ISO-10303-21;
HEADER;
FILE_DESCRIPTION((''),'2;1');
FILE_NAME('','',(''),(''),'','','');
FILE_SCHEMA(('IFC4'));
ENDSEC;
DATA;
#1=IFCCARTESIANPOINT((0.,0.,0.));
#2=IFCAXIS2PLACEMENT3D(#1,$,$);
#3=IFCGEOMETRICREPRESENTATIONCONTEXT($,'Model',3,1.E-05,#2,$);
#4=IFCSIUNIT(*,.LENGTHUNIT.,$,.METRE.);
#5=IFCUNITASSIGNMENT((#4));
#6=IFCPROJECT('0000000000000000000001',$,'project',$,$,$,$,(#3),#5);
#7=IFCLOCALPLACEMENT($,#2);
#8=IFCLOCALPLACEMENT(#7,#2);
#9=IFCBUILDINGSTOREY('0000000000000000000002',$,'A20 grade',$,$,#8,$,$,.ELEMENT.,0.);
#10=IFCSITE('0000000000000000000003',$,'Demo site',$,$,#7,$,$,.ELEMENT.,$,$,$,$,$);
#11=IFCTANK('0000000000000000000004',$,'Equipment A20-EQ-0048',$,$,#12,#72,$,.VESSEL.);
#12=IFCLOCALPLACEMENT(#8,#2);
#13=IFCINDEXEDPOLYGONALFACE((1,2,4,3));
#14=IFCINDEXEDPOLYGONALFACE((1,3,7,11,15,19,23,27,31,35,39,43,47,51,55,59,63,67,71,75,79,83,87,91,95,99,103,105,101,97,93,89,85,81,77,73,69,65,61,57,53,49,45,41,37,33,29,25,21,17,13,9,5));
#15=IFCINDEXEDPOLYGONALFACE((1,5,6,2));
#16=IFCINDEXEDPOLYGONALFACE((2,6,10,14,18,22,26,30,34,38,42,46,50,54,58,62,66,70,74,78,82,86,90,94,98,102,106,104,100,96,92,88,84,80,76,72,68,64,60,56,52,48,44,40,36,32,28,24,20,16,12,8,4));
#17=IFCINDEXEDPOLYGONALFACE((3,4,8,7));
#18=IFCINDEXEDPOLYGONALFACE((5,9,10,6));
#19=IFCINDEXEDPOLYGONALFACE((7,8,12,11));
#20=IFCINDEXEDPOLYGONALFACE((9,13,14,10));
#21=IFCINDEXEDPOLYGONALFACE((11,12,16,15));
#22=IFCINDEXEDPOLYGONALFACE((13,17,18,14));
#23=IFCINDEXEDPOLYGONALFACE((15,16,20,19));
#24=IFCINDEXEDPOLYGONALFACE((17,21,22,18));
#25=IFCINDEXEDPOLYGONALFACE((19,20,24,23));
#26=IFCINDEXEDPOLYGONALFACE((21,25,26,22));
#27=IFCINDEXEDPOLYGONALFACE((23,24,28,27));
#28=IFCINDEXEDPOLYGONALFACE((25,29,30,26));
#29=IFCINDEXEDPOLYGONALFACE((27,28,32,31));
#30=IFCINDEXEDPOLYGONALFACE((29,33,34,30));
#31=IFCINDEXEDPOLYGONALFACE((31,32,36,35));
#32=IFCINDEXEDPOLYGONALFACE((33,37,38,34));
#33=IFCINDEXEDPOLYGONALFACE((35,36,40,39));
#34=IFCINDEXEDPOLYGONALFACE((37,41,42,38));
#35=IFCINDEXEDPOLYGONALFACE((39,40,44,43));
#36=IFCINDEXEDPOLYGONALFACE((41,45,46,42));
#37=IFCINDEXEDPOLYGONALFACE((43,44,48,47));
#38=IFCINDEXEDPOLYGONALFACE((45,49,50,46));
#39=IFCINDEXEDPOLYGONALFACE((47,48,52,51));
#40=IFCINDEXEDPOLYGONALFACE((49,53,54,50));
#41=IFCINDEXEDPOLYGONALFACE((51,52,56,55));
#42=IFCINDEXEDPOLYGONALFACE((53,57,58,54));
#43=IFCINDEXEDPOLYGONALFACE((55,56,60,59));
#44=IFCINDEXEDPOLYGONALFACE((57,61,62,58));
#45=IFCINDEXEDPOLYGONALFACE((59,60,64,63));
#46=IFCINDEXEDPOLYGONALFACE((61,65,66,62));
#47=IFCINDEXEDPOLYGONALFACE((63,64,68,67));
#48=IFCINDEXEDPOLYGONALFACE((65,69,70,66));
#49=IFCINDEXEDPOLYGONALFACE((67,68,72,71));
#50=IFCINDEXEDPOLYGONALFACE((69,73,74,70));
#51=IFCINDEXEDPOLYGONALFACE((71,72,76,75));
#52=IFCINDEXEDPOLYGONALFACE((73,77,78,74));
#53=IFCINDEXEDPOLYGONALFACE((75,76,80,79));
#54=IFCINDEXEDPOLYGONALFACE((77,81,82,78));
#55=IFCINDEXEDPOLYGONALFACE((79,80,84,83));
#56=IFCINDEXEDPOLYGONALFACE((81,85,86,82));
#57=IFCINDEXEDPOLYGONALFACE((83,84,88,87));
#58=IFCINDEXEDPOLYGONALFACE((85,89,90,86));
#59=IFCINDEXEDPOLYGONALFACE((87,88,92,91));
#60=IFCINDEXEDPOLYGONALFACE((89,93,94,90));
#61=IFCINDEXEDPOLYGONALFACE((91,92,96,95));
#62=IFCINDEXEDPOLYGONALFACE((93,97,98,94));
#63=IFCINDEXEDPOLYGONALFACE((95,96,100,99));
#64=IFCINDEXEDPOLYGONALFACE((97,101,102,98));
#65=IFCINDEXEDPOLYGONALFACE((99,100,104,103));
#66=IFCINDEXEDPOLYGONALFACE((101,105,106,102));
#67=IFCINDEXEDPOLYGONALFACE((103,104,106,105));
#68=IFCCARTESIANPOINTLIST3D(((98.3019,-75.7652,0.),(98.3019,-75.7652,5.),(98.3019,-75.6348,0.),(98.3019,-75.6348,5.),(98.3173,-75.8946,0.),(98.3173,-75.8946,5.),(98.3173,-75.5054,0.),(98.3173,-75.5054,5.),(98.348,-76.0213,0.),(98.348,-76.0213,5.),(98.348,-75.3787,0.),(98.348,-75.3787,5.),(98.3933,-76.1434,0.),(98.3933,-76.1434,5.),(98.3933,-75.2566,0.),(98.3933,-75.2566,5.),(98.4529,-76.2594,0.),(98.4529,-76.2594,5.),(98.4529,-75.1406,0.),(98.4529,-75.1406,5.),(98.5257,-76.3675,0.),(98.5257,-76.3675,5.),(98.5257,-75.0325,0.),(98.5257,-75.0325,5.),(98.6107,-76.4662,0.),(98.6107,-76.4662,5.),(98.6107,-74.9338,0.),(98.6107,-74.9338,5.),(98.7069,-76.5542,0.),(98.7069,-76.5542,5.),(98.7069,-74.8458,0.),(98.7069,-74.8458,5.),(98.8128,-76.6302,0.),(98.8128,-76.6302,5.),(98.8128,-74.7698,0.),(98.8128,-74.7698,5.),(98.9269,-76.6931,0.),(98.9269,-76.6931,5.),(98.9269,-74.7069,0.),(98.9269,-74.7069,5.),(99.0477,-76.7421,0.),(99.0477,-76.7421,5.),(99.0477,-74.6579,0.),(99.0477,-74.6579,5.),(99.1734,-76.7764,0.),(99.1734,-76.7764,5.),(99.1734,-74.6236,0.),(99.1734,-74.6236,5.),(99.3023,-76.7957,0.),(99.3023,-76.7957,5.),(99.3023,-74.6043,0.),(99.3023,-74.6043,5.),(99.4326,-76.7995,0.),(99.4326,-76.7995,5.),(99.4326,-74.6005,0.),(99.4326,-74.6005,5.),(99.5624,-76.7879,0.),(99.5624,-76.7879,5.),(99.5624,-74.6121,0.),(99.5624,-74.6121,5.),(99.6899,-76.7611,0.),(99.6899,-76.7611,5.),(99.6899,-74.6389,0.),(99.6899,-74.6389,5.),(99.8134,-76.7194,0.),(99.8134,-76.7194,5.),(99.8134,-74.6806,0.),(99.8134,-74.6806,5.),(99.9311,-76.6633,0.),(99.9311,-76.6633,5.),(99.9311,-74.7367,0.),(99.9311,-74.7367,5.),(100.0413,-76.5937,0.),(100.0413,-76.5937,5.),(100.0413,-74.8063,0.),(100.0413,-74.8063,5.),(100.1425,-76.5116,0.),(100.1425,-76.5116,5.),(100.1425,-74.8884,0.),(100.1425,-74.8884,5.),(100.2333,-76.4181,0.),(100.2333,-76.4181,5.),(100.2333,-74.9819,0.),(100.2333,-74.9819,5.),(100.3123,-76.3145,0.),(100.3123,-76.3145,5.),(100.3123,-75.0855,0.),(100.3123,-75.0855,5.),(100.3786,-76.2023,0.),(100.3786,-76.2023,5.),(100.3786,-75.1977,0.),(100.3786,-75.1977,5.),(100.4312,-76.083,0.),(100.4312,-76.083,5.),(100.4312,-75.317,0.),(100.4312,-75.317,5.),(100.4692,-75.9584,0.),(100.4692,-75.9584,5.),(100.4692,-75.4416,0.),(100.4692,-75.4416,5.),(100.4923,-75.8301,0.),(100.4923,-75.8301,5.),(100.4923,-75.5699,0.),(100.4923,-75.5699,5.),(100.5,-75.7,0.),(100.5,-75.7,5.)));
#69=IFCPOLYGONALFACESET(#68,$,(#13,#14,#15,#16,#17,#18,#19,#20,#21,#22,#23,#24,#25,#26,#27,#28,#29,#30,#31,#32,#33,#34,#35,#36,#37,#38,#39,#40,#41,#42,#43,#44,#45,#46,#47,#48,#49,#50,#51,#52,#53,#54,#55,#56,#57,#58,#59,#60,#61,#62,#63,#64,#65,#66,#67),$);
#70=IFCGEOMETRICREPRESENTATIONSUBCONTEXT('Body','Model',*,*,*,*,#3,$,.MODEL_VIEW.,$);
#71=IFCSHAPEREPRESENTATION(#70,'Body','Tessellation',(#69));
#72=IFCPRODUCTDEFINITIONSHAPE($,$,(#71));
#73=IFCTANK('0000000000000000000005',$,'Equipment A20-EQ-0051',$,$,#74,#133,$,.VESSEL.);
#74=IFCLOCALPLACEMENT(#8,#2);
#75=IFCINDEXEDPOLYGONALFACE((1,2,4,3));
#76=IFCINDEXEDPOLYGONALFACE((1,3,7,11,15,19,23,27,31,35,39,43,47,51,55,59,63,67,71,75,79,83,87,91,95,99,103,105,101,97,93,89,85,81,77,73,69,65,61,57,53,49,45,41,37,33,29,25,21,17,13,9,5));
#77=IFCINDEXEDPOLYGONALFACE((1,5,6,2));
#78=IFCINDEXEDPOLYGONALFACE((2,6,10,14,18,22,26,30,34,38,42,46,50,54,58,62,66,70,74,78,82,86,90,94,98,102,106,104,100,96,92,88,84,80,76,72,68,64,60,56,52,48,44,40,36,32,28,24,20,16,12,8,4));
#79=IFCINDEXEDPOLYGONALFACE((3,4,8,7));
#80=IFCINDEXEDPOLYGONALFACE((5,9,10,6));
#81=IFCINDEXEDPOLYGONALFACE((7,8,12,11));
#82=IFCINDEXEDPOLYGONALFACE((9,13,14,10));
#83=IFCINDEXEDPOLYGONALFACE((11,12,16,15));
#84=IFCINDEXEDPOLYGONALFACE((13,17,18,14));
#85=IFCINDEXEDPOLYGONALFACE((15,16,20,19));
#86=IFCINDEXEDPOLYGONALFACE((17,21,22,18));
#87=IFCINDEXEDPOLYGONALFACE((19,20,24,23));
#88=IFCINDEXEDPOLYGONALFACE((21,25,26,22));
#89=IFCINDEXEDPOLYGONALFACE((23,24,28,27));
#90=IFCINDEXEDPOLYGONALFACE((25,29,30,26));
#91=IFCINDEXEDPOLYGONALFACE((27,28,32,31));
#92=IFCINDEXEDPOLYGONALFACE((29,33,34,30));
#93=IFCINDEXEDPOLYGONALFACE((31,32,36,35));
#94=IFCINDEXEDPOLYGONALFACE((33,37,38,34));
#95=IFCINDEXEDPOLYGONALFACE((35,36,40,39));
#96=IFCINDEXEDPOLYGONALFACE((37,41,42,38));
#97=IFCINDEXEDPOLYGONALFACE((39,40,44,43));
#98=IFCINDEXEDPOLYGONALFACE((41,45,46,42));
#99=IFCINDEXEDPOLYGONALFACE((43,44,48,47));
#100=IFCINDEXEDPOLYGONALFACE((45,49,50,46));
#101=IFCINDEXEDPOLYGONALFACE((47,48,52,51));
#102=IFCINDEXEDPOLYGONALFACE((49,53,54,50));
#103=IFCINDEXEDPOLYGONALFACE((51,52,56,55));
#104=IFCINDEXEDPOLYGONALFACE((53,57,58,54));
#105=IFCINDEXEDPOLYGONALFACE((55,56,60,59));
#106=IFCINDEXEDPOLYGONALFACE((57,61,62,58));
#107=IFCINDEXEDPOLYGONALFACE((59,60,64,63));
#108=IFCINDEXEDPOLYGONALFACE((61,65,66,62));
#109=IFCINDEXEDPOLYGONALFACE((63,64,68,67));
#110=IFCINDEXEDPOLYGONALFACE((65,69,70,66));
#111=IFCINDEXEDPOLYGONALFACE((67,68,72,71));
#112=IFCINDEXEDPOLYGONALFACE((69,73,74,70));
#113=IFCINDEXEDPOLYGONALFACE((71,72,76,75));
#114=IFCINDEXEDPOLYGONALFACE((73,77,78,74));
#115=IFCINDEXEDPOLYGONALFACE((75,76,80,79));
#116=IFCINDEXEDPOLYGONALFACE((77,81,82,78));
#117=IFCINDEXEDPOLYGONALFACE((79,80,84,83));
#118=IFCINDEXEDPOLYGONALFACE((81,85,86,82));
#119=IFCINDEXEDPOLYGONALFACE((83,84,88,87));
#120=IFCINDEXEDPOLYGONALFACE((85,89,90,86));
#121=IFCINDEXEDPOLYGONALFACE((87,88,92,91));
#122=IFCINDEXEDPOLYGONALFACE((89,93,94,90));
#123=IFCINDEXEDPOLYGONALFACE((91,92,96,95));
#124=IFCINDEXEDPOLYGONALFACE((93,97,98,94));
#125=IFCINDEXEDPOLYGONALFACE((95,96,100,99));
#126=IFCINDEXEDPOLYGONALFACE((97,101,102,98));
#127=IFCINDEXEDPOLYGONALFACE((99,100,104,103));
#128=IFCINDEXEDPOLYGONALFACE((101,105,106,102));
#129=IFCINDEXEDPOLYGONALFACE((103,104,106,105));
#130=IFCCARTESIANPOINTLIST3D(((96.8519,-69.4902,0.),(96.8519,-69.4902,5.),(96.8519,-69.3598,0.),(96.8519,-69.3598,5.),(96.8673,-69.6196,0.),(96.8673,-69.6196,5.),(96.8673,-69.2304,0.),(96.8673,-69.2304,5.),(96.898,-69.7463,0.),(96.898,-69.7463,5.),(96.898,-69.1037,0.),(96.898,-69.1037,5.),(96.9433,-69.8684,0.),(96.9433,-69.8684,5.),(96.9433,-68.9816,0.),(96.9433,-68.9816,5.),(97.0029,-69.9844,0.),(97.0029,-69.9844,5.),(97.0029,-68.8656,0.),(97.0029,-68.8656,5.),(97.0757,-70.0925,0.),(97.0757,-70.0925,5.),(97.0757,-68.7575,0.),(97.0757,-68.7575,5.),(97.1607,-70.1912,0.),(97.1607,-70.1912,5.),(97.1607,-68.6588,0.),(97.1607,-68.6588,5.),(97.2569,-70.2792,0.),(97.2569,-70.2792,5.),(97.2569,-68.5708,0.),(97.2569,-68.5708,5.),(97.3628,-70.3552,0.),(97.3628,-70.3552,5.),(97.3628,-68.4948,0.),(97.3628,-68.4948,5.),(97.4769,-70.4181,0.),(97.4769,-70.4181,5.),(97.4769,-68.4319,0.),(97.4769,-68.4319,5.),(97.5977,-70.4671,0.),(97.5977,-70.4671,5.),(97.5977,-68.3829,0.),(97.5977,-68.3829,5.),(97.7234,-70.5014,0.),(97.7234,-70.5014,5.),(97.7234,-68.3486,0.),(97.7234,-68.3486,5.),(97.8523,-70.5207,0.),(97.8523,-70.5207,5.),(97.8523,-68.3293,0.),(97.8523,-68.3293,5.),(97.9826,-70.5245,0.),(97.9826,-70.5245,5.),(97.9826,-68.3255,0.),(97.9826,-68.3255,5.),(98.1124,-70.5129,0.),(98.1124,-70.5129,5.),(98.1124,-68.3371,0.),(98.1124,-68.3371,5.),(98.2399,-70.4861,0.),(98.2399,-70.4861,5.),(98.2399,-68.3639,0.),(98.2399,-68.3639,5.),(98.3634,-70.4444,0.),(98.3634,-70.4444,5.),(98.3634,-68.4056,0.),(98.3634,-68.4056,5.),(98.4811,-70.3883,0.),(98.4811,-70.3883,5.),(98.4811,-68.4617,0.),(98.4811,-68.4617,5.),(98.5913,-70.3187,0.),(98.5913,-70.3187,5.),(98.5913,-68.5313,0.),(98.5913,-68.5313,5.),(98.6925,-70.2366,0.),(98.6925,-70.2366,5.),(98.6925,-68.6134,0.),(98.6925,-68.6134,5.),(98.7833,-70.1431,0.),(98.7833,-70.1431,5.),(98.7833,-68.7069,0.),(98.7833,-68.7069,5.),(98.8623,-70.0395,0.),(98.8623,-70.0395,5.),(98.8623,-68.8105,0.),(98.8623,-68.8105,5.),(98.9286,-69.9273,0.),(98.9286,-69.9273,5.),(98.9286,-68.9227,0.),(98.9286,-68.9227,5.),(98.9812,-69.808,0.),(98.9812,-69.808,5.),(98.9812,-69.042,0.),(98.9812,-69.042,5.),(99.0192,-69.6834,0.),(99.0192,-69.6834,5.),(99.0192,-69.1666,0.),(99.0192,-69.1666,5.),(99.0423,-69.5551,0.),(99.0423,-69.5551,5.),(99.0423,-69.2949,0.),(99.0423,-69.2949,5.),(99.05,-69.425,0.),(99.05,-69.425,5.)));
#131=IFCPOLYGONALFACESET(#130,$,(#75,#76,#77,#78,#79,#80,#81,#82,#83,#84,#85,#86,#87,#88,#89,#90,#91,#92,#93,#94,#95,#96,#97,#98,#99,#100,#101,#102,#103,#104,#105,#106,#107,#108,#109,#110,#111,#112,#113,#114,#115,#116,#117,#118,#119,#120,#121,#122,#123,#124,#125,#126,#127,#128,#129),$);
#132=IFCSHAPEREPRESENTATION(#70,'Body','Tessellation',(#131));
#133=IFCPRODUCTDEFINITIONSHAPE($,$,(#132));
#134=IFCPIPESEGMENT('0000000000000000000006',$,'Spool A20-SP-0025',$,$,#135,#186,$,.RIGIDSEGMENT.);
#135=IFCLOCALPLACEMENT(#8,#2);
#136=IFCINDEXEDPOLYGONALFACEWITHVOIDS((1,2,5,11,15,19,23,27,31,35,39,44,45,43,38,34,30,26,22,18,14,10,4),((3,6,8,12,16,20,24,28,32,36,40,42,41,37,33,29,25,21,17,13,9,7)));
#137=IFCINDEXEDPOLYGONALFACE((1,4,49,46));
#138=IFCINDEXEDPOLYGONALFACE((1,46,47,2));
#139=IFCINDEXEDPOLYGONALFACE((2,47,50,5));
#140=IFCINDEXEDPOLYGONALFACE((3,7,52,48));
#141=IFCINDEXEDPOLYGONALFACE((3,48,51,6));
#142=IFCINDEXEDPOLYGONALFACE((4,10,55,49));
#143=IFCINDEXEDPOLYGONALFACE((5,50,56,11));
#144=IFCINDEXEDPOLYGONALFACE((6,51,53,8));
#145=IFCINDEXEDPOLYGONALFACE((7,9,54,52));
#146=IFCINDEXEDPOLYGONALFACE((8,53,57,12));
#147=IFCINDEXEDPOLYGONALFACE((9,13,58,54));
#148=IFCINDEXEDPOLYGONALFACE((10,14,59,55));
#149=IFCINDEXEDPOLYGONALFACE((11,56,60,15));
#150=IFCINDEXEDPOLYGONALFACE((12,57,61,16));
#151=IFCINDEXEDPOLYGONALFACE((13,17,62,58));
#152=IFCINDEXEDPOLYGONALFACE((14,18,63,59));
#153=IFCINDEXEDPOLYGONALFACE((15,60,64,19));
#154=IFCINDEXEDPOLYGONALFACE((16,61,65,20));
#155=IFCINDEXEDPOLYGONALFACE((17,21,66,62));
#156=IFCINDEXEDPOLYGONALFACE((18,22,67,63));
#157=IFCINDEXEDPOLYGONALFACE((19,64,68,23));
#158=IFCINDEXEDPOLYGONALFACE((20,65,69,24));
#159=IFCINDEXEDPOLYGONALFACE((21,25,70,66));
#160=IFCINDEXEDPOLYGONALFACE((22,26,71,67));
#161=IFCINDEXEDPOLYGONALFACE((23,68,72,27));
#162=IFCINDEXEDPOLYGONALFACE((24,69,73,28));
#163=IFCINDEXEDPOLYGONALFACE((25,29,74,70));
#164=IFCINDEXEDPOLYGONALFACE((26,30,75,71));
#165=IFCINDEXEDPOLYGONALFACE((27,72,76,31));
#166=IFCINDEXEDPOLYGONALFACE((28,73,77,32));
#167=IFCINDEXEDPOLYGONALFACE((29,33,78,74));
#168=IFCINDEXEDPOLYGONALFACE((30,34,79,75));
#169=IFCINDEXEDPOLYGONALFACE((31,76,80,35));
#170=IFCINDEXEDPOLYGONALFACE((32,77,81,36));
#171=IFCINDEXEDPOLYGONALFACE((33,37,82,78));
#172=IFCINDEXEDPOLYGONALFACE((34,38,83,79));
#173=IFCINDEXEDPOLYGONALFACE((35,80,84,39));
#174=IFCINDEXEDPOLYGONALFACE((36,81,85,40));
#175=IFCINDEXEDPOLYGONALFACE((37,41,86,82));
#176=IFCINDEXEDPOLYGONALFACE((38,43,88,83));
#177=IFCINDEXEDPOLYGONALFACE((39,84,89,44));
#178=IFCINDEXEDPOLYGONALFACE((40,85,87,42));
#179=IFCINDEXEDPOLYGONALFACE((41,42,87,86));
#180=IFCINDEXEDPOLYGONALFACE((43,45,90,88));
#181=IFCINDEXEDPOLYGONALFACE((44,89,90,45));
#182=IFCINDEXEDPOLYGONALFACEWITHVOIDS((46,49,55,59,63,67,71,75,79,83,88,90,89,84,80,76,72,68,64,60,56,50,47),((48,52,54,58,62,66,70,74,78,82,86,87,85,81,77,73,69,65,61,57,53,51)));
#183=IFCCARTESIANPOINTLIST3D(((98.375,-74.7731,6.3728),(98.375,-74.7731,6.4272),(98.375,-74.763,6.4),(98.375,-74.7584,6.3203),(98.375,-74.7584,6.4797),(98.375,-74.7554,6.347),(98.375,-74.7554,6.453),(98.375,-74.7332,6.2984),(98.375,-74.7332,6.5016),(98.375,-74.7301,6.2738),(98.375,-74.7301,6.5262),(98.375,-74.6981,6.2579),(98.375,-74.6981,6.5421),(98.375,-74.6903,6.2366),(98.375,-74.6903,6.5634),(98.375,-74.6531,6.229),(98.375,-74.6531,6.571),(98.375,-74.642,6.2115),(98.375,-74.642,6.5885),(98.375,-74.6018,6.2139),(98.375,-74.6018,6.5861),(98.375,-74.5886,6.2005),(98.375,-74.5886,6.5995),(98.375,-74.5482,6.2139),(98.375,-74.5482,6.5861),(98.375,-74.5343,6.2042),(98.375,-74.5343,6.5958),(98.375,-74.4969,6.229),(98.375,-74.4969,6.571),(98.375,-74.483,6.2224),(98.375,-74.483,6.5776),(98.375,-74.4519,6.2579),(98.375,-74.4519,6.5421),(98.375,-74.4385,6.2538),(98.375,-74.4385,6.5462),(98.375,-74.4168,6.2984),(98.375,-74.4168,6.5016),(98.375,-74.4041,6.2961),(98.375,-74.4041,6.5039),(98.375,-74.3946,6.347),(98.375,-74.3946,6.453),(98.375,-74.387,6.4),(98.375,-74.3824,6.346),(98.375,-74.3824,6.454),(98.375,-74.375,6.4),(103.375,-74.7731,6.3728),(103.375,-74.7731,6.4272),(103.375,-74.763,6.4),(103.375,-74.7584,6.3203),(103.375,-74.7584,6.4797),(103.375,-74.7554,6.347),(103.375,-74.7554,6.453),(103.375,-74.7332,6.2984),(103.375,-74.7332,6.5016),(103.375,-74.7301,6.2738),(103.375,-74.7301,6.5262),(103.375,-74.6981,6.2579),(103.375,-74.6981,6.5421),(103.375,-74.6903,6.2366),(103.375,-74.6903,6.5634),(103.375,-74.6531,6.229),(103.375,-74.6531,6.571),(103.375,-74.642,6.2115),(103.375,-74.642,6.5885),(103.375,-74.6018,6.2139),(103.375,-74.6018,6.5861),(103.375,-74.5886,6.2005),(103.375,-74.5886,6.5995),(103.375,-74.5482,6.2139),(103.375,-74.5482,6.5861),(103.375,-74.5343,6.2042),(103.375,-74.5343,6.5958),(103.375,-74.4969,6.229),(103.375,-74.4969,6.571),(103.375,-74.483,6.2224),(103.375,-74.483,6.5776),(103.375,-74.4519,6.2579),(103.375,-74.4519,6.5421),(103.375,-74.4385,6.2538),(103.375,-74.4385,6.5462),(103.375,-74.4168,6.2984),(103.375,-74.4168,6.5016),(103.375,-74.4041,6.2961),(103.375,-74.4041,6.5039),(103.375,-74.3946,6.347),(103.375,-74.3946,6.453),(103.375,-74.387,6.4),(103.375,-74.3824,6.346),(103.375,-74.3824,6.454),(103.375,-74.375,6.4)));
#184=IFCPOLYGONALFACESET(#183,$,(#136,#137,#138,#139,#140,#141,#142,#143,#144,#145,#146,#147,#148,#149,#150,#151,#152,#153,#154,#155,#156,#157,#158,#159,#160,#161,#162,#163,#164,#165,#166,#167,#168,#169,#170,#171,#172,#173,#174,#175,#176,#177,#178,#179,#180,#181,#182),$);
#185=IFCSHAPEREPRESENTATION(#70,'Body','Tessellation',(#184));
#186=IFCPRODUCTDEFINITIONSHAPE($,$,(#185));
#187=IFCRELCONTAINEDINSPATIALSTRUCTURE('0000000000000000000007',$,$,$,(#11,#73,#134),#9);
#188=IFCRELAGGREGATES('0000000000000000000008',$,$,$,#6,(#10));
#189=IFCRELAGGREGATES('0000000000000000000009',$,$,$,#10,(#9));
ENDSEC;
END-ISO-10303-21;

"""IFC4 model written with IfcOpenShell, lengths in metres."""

from ifc_helpers import new_model, si_unit, frame, origin, place, context, subcontext, project, spatial, circle, hollow_circle, extrude, element, save


model = new_model("IFC4")

# Units and contexts
model_context = context("Model", 3, precision=1e-05, world=origin())
body_context = subcontext(model_context, "Body", "Model", "MODEL_VIEW")
ifc_project = project(units=[si_unit("LENGTHUNIT", "METRE")], contexts=[model_context])

# Site, storey
site_placement = place(None, origin())
site = spatial("IfcSite", under=ifc_project, at=site_placement, Name="Demo site", CompositionType="ELEMENT")
storey_placement = place(site_placement, origin())
storey = spatial("IfcBuildingStorey", under=site, at=storey_placement, Name="A20 grade", CompositionType="ELEMENT", Elevation=0.0)

# Tanks
for number, where, name in (
    (1, (99.4, -75.7, 0.0), "Equipment A20-EQ-0048"),
    (2, (97.95, -69.425, 0.0), "Equipment A20-EQ-0051"),
):
    element("IfcTank", number, at=place(storey_placement, frame(where)), inside=storey, Name=name, PredefinedType="VESSEL", context=body_context, shape_type="SweptSolid", body=[
        extrude(circle(Radius=1.1), origin(), (0.0, 0.0, 1.0), 5.0),
    ])

# Pipe segment
for number, where, name in (
    (3, (98.375, -74.575, 6.4), "Spool A20-SP-0025"),
):
    element("IfcPipeSegment", number, at=place(storey_placement, frame(where)), inside=storey, Name=name, PredefinedType="RIGIDSEGMENT", context=body_context, shape_type="SweptSolid", body=[
        extrude(hollow_circle(Radius=0.2, WallThickness=0.012), frame((0.0, 0.0, 0.0), z_axis=(1.0, 0.0, 0.0), x_axis=(0.0, 1.0, 0.0)), (0.0, 0.0, 1.0), 5.0),
    ])

save(model, "model.ifc")
